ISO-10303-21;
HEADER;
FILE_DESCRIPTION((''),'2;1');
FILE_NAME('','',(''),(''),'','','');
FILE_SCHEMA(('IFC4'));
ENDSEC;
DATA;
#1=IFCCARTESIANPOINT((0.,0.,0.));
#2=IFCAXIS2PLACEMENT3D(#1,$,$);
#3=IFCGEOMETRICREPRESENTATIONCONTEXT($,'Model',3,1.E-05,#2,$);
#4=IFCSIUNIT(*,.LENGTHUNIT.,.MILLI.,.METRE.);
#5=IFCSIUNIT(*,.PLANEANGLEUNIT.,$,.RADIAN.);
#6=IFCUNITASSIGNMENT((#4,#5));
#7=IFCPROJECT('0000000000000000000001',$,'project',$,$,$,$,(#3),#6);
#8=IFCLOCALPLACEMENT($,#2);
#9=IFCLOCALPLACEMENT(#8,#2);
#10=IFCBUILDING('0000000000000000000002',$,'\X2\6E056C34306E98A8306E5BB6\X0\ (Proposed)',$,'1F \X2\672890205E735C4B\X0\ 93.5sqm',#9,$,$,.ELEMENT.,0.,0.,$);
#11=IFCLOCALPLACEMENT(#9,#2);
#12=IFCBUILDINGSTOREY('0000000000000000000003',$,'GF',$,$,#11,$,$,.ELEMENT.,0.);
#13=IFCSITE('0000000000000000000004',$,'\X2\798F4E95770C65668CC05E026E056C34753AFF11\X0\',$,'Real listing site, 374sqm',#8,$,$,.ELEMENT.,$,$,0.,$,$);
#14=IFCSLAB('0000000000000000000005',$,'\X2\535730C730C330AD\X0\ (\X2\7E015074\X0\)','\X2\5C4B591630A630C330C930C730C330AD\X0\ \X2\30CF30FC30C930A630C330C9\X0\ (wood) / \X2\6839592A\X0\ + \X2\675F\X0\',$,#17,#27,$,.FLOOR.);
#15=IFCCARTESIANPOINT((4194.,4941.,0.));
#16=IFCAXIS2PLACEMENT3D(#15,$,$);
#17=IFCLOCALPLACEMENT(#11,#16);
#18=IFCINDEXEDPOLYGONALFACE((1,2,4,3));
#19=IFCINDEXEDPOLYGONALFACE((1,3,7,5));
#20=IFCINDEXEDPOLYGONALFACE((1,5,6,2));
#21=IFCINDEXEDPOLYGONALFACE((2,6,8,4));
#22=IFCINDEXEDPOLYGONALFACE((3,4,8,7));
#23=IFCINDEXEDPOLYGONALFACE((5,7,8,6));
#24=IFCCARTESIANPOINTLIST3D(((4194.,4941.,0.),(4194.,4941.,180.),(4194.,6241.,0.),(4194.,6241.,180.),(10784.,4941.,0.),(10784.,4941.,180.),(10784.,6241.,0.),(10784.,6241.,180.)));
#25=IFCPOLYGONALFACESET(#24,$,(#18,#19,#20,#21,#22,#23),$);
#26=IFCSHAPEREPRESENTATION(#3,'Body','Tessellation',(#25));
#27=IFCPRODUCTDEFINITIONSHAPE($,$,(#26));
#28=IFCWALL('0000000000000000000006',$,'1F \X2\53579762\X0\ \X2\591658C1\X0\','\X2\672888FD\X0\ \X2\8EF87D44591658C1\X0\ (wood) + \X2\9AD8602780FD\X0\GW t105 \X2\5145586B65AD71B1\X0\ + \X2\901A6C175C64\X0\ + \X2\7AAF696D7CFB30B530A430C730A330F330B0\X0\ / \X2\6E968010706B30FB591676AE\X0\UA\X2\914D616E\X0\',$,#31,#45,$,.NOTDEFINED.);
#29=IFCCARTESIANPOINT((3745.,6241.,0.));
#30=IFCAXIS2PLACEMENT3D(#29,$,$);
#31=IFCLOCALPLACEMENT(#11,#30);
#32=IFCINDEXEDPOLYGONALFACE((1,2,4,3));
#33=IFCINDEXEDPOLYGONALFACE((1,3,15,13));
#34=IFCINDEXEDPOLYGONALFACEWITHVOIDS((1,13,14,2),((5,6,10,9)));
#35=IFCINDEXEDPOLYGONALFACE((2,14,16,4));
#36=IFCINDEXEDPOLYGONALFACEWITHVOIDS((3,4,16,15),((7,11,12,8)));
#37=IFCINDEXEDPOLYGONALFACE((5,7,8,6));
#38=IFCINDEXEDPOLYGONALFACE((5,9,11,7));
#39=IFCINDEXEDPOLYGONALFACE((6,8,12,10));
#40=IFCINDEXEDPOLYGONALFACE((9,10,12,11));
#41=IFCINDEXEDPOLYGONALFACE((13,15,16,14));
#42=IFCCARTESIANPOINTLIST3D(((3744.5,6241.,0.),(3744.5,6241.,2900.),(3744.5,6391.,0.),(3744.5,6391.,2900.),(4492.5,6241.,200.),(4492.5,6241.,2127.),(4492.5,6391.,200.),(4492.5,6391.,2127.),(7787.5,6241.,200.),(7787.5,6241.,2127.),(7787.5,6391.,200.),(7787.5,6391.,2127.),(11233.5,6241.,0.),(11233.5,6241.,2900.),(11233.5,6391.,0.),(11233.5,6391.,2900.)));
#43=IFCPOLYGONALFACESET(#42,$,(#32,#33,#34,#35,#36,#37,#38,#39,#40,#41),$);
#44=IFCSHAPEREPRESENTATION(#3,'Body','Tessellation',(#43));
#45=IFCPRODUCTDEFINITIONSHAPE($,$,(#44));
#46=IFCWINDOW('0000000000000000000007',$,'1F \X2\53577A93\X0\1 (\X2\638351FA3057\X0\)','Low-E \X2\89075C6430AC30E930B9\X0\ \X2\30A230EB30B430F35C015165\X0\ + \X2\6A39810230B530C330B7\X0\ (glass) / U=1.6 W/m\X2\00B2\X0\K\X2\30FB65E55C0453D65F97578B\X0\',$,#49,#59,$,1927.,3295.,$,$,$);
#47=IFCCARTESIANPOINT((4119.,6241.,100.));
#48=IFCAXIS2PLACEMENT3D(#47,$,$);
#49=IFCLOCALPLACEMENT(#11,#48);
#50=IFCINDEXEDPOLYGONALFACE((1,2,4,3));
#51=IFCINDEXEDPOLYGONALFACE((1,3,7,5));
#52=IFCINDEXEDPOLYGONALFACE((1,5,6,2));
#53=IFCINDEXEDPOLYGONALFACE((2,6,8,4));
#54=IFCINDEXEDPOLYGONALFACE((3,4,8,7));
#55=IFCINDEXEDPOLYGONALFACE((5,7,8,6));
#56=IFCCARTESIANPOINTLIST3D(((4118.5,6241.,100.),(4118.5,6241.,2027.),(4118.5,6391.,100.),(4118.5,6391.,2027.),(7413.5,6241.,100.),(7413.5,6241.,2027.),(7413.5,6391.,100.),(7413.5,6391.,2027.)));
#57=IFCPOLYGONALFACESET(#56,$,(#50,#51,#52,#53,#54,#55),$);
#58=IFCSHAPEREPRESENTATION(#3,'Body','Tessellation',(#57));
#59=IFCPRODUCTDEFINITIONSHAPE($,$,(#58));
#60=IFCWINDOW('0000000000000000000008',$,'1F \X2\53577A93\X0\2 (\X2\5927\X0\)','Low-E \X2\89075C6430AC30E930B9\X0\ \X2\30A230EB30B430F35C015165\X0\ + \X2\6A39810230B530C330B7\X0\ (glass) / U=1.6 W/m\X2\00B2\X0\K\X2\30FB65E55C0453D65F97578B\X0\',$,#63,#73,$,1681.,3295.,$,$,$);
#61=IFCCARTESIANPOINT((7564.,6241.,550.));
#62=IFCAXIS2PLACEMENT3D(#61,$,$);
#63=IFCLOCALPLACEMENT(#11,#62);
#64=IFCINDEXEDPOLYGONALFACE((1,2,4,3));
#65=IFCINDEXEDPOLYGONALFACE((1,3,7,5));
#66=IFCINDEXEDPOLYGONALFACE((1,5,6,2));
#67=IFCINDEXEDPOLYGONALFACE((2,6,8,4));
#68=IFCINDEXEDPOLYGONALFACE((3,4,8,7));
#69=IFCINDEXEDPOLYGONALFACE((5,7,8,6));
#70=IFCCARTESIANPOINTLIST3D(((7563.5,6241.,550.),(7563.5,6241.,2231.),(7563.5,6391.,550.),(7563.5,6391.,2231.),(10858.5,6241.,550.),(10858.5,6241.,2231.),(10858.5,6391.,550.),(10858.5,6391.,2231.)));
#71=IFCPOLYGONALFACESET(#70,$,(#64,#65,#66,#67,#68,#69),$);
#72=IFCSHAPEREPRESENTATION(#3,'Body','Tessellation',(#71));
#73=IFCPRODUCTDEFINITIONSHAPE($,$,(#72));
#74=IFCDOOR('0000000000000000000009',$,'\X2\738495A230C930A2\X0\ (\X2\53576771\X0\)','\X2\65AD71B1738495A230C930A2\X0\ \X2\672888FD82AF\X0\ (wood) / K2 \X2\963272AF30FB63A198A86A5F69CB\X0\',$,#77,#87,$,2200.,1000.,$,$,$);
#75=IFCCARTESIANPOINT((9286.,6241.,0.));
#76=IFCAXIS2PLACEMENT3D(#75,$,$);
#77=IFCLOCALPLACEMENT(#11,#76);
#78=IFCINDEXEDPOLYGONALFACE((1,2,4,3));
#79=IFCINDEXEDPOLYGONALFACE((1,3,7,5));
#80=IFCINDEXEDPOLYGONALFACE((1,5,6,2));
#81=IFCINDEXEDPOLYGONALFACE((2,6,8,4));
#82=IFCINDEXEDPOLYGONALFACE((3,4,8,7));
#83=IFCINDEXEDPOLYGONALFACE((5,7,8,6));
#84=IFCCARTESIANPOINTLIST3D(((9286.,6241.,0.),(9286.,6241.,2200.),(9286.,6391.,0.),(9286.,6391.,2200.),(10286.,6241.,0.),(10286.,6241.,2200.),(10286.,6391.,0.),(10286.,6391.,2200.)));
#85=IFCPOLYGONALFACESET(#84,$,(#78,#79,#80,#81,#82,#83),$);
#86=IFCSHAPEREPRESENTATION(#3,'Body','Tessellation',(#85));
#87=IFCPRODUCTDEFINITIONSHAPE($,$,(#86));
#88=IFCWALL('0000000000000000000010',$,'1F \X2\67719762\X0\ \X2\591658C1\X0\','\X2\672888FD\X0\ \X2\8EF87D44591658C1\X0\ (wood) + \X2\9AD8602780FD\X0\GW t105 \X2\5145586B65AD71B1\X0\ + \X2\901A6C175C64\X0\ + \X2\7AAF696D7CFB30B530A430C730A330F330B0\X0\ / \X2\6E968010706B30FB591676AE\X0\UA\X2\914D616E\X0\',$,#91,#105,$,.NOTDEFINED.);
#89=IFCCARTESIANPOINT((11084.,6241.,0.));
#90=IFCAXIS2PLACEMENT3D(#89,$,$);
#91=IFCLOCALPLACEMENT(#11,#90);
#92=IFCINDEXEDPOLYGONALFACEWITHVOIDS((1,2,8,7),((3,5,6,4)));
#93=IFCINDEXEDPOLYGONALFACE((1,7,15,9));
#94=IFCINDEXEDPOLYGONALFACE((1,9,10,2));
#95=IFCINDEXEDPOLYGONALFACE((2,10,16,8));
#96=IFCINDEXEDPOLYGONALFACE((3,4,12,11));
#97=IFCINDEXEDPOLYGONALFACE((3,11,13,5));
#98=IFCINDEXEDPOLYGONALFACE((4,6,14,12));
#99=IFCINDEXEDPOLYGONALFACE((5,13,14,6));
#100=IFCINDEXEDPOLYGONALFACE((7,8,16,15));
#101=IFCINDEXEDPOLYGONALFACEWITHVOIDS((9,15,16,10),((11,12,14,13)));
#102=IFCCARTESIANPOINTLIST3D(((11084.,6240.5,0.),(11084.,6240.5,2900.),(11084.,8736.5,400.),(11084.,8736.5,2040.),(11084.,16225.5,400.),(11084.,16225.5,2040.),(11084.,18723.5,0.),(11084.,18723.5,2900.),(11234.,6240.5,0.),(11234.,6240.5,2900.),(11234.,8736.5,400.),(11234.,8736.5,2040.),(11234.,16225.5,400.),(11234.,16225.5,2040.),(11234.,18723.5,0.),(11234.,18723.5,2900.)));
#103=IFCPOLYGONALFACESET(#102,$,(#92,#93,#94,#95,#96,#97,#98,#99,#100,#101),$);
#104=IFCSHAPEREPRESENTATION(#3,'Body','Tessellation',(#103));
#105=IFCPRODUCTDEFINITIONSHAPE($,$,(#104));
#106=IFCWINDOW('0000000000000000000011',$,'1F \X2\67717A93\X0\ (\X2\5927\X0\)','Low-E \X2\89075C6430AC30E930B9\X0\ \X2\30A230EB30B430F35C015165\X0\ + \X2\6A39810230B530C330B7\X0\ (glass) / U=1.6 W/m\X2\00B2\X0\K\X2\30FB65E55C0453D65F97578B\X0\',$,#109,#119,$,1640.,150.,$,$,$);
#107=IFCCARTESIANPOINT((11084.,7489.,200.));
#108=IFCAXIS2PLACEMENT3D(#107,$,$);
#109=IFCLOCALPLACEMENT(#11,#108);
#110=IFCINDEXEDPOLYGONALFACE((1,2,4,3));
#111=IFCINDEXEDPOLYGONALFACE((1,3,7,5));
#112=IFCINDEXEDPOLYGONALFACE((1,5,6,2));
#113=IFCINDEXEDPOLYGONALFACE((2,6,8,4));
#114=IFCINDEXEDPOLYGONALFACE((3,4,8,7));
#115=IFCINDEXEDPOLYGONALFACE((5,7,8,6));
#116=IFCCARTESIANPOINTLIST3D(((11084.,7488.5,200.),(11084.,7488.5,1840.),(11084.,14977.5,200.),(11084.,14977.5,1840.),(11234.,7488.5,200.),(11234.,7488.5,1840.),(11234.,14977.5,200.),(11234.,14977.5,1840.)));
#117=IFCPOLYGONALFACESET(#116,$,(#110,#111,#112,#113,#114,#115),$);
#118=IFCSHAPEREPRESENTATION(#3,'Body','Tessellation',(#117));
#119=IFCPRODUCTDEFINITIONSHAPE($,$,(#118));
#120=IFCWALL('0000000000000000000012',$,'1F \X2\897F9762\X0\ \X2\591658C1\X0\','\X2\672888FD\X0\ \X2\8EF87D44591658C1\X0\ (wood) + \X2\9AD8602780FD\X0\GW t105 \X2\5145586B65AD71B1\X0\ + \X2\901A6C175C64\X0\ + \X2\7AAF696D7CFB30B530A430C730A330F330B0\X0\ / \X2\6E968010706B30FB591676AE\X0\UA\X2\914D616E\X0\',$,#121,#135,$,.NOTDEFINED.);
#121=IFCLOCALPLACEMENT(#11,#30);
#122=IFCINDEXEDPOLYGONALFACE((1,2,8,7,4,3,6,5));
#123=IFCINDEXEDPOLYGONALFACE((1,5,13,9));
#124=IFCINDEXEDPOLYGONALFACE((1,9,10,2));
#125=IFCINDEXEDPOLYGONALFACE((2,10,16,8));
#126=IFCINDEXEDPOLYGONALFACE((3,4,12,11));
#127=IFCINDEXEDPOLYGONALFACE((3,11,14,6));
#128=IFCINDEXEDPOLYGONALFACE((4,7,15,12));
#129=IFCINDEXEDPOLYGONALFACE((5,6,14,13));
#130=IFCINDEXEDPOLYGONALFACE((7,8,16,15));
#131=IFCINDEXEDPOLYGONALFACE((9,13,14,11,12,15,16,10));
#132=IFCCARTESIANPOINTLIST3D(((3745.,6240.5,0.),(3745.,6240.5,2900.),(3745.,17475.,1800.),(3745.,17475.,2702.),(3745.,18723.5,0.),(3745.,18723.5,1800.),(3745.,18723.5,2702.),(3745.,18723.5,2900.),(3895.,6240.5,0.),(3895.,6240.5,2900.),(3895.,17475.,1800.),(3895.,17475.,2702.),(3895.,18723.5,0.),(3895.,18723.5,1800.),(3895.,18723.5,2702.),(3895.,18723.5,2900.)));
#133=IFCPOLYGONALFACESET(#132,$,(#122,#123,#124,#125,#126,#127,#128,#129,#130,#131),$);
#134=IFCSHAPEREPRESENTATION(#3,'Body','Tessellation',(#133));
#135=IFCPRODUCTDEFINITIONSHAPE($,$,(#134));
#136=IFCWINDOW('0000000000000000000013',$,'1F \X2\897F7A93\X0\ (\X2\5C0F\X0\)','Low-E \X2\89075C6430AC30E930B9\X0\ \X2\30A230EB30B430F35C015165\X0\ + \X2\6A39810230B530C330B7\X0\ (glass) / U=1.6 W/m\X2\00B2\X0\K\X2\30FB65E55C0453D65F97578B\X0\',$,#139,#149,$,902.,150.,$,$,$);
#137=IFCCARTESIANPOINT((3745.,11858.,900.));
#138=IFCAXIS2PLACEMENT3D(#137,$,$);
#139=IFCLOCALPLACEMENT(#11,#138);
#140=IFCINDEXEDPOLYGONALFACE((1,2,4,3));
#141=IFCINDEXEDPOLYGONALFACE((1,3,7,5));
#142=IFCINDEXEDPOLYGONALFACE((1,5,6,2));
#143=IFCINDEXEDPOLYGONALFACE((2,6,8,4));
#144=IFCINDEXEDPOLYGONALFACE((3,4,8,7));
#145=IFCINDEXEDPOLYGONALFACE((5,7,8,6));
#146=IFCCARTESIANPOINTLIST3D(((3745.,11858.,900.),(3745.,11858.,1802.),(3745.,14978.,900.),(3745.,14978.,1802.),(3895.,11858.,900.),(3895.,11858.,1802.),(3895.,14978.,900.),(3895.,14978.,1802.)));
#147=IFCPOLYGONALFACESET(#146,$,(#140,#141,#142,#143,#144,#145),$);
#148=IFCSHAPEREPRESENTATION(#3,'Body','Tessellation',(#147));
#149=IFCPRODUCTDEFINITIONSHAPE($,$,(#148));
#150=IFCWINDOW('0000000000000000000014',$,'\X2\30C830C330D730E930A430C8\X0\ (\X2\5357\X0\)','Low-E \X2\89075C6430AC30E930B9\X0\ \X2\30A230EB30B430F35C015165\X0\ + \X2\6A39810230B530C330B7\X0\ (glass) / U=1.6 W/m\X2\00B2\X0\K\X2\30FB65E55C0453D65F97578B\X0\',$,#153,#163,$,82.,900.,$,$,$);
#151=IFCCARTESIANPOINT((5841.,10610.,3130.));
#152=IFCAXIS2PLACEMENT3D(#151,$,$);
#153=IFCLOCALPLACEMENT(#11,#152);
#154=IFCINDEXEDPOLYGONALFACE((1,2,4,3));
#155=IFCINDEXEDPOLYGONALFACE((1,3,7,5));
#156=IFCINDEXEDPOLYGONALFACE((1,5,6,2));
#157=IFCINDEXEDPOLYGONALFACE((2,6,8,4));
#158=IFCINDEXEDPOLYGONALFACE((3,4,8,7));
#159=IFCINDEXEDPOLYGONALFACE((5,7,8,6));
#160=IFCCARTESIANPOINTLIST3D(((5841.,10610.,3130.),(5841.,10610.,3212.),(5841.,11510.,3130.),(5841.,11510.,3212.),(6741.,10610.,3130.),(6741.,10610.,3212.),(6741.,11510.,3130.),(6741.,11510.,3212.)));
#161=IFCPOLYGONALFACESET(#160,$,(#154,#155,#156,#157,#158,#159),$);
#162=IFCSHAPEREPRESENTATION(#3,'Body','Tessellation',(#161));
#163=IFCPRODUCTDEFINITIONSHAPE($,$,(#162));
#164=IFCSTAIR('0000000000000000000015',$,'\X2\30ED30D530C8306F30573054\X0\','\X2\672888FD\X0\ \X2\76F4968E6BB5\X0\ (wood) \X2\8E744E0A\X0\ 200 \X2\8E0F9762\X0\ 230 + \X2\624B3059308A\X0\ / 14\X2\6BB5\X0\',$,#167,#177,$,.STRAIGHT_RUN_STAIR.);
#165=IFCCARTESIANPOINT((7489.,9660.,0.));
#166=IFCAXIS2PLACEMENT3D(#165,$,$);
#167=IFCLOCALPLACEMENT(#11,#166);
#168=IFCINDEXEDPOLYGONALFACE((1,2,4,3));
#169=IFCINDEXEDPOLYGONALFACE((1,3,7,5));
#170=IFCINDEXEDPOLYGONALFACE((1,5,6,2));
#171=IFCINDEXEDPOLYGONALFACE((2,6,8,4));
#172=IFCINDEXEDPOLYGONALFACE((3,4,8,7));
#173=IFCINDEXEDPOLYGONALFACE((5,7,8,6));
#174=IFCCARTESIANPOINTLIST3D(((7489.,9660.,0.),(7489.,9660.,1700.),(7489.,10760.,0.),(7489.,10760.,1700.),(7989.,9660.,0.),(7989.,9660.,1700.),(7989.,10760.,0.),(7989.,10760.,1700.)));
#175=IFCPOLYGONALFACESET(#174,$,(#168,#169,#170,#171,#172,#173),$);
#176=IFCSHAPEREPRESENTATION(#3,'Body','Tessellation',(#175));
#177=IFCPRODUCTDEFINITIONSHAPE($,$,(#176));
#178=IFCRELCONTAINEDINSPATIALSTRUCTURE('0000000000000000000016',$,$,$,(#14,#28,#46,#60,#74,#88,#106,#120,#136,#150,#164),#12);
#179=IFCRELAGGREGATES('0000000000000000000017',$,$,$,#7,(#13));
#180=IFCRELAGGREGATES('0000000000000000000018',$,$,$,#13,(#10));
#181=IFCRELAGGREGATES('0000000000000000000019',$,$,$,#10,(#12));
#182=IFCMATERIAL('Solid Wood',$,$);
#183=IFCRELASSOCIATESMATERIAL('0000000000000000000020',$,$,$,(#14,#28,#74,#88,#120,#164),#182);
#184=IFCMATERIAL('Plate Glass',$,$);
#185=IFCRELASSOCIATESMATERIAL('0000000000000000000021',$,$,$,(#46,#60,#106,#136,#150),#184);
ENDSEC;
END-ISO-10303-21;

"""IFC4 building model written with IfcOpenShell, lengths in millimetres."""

from ifc_helpers import new_model, si_unit, frame, frame_2d, origin, place, context, project, spatial, rectangle, extrude, material, element, fill, save


model = new_model("IFC4")

# Units and contexts
model_context = context("Model", 3, precision=1e-05, world=origin())
ifc_project = project(units=[si_unit("LENGTHUNIT", "METRE", prefix="MILLI"), si_unit("PLANEANGLEUNIT", "RADIAN")], contexts=[model_context])

# Site, building, storey
site_placement = place(None, origin())
site = spatial("IfcSite", under=ifc_project, at=site_placement, Name="福井県敦賀市清水町１", ObjectType="Real listing site, 374sqm", CompositionType="ELEMENT", RefElevation=0.0)
building_placement = place(site_placement, origin())
building = spatial("IfcBuilding", under=site, at=building_placement, Name="清水の風の家 (Proposed)", ObjectType="1F 木造平屋 93.5sqm", CompositionType="ELEMENT", ElevationOfRefHeight=0.0, ElevationOfTerrain=0.0)
storey_placement = place(building_placement, origin())
storey = spatial("IfcBuildingStorey", under=building, at=storey_placement, Name="GF", CompositionType="ELEMENT", Elevation=0.0)

# Slab
ifc_material_1 = material(Name="Solid Wood")
slab_1_placement = place(storey_placement, frame((4194.0, 4941.0, 0.0)))
element("IfcSlab", 1, at=slab_1_placement, inside=storey, material=ifc_material_1, Name="南デッキ (縁側)", Description="屋外ウッドデッキ ハードウッド (wood) / 根太 + 束", PredefinedType="FLOOR", context=model_context, shape_type="SweptSolid", body=[
    extrude(rectangle(XDim=6590.0, YDim=1300.0, at=frame_2d((3295.0, 650.0))), frame((4194.0, 4941.0, 0.0)), (0.0, 0.0, 1.0), 180.0),
])

# Wall, openings, windows, door
wall_1_placement = place(storey_placement, frame((3745.0, 6241.0, 0.0)))
wall_1 = element("IfcWall", 2, at=wall_1_placement, inside=storey, material=ifc_material_1, Name="1F 南面 外壁", Description="木製 軸組外壁 (wood) + 高性能GW t105 充填断熱 + 通気層 + 窯業系サイディング / 準耐火・外皮UA配慮", PredefinedType="NOTDEFINED", context=model_context, shape_type="SweptSolid", body=[
    extrude(rectangle(XDim=7489.0, YDim=150.0, at=frame_2d((3744.0, 75.0))), frame((3745.0, 6241.0, 0.0)), (0.0, 0.0, 1.0), 2900.0),
])
opening_1_placement = place(storey_placement, frame((4119.0, 6241.0, 100.0)))
opening_1 = element("IfcOpeningElement", 3, at=opening_1_placement, cuts=wall_1, PredefinedType="NOTDEFINED", context=model_context, shape_type="SweptSolid", body=[
    extrude(rectangle(XDim=3295.0, YDim=150.0, at=frame_2d((1647.0, 75.0))), frame((4119.0, 6241.0, 100.0)), (0.0, 0.0, 1.0), 1927.0),
])
opening_2_placement = place(storey_placement, frame((7564.0, 6241.0, 550.0)))
opening_2 = element("IfcOpeningElement", 4, at=opening_2_placement, cuts=wall_1, PredefinedType="NOTDEFINED", context=model_context, shape_type="SweptSolid", body=[
    extrude(rectangle(XDim=3295.0, YDim=150.0, at=frame_2d((1647.0, 75.0))), frame((7564.0, 6241.0, 550.0)), (0.0, 0.0, 1.0), 1681.0),
])
opening_3_placement = place(storey_placement, frame((9286.0, 6241.0, 0.0)))
opening_3 = element("IfcOpeningElement", 5, at=opening_3_placement, cuts=wall_1, PredefinedType="NOTDEFINED", context=model_context, shape_type="SweptSolid", body=[
    extrude(rectangle(XDim=1000.0, YDim=150.0, at=frame_2d((500.0, 75.0))), frame((9286.0, 6241.0, 0.0)), (0.0, 0.0, 1.0), 2200.0),
])
ifc_material_2 = material(Name="Plate Glass")
window_1_placement = place(storey_placement, frame((4119.0, 6241.0, 100.0)))
window_1 = element("IfcWindow", 6, at=window_1_placement, inside=storey, material=ifc_material_2, Name="1F 南窓1 (掃出し)", Description="Low-E 複層ガラス アルゴン封入 + 樹脂サッシ (glass) / U=1.6 W/m²K・日射取得型", OverallHeight=1927.0, OverallWidth=3295.0, context=model_context, shape_type="SweptSolid", body=[
    extrude(rectangle(XDim=3295.0, YDim=150.0, at=frame_2d((1647.0, 75.0))), frame((4119.0, 6241.0, 100.0)), (0.0, 0.0, 1.0), 1927.0),
])
fill(opening_1, window_1)
window_2_placement = place(storey_placement, frame((7564.0, 6241.0, 550.0)))
window_2 = element("IfcWindow", 7, at=window_2_placement, inside=storey, material=ifc_material_2, Name="1F 南窓2 (大)", Description="Low-E 複層ガラス アルゴン封入 + 樹脂サッシ (glass) / U=1.6 W/m²K・日射取得型", OverallHeight=1681.0, OverallWidth=3295.0, context=model_context, shape_type="SweptSolid", body=[
    extrude(rectangle(XDim=3295.0, YDim=150.0, at=frame_2d((1647.0, 75.0))), frame((7564.0, 6241.0, 550.0)), (0.0, 0.0, 1.0), 1681.0),
])
fill(opening_2, window_2)
door_placement = place(storey_placement, frame((9286.0, 6241.0, 0.0)))
door = element("IfcDoor", 8, at=door_placement, inside=storey, material=ifc_material_1, Name="玄関ドア (南東)", Description="断熱玄関ドア 木製芯 (wood) / K2 防犯・採風機構", OverallHeight=2200.0, OverallWidth=1000.0, context=model_context, shape_type="SweptSolid", body=[
    extrude(rectangle(XDim=1000.0, YDim=150.0, at=frame_2d((500.0, 75.0))), frame((9286.0, 6241.0, 0.0)), (0.0, 0.0, 1.0), 2200.0),
])
fill(opening_3, door)

# Walls, openings, windows
wall_2_placement = place(storey_placement, frame((11084.0, 6241.0, 0.0)))
wall_2 = element("IfcWall", 9, at=wall_2_placement, inside=storey, material=ifc_material_1, Name="1F 東面 外壁", Description="木製 軸組外壁 (wood) + 高性能GW t105 充填断熱 + 通気層 + 窯業系サイディング / 準耐火・外皮UA配慮", PredefinedType="NOTDEFINED", context=model_context, shape_type="SweptSolid", body=[
    extrude(rectangle(XDim=150.0, YDim=12483.0, at=frame_2d((75.0, 6241.0))), frame((11084.0, 6241.0, 0.0)), (0.0, 0.0, 1.0), 2900.0),
])
opening_4_placement = place(storey_placement, frame((11084.0, 7489.0, 200.0)))
opening_4 = element("IfcOpeningElement", 10, at=opening_4_placement, cuts=wall_2, PredefinedType="NOTDEFINED", context=model_context, shape_type="SweptSolid", body=[
    extrude(rectangle(XDim=150.0, YDim=7489.0, at=frame_2d((75.0, 3744.0))), frame((11084.0, 7489.0, 200.0)), (0.0, 0.0, 1.0), 1640.0),
])
window_3_placement = place(storey_placement, frame((11084.0, 7489.0, 200.0)))
window_3 = element("IfcWindow", 11, at=window_3_placement, inside=storey, material=ifc_material_2, Name="1F 東窓 (大)", Description="Low-E 複層ガラス アルゴン封入 + 樹脂サッシ (glass) / U=1.6 W/m²K・日射取得型", OverallHeight=1640.0, OverallWidth=150.0, context=model_context, shape_type="SweptSolid", body=[
    extrude(rectangle(XDim=150.0, YDim=7489.0, at=frame_2d((75.0, 3744.0))), frame((11084.0, 7489.0, 200.0)), (0.0, 0.0, 1.0), 1640.0),
])
fill(opening_4, window_3)
wall_3_placement = place(storey_placement, frame((3745.0, 6241.0, 0.0)))
wall_3 = element("IfcWall", 12, at=wall_3_placement, inside=storey, material=ifc_material_1, Name="1F 西面 外壁", Description="木製 軸組外壁 (wood) + 高性能GW t105 充填断熱 + 通気層 + 窯業系サイディング / 準耐火・外皮UA配慮", PredefinedType="NOTDEFINED", context=model_context, shape_type="SweptSolid", body=[
    extrude(rectangle(XDim=150.0, YDim=12483.0, at=frame_2d((75.0, 6241.0))), frame((3745.0, 6241.0, 0.0)), (0.0, 0.0, 1.0), 2900.0),
])
opening_5_placement = place(storey_placement, frame((3745.0, 11858.0, 900.0)))
opening_5 = element("IfcOpeningElement", 13, at=opening_5_placement, cuts=wall_3, PredefinedType="NOTDEFINED", context=model_context, shape_type="SweptSolid", body=[
    extrude(rectangle(XDim=150.0, YDim=3120.0, at=frame_2d((75.0, 1560.0))), frame((3745.0, 11858.0, 900.0)), (0.0, 0.0, 1.0), 902.0),
])
window_4_placement = place(storey_placement, frame((3745.0, 11858.0, 900.0)))
window_4 = element("IfcWindow", 14, at=window_4_placement, inside=storey, material=ifc_material_2, Name="1F 西窓 (小)", Description="Low-E 複層ガラス アルゴン封入 + 樹脂サッシ (glass) / U=1.6 W/m²K・日射取得型", OverallHeight=902.0, OverallWidth=150.0, context=model_context, shape_type="SweptSolid", body=[
    extrude(rectangle(XDim=150.0, YDim=3120.0, at=frame_2d((75.0, 1560.0))), frame((3745.0, 11858.0, 900.0)), (0.0, 0.0, 1.0), 902.0),
])
fill(opening_5, window_4)

# Window
window_5_placement = place(storey_placement, frame((5841.0, 10610.0, 3130.0)))
element("IfcWindow", 15, at=window_5_placement, inside=storey, material=ifc_material_2, Name="トップライト (南)", Description="Low-E 複層ガラス アルゴン封入 + 樹脂サッシ (glass) / U=1.6 W/m²K・日射取得型", OverallHeight=82.0, OverallWidth=900.0, context=model_context, shape_type="SweptSolid", body=[
    extrude(rectangle(XDim=900.0, YDim=900.0, at=frame_2d((450.0, 450.0))), frame((5841.0, 10610.0, 3130.0)), (0.0, 0.0, 1.0), 82.0),
])

# Stair
stair_placement = place(storey_placement, frame((7489.0, 9660.0, 0.0)))
element("IfcStair", 16, at=stair_placement, inside=storey, material=ifc_material_1, Name="ロフトはしご", Description="木製 直階段 (wood) 蹴上 200 踏面 230 + 手すり / 14段", PredefinedType="STRAIGHT_RUN_STAIR", context=model_context, shape_type="SweptSolid", body=[
    extrude(rectangle(XDim=500.0, YDim=1100.0, at=frame_2d((250.0, 550.0))), frame((7489.0, 9660.0, 0.0)), (0.0, 0.0, 1.0), 1700.0),
])

save(model, "model.ifc")
